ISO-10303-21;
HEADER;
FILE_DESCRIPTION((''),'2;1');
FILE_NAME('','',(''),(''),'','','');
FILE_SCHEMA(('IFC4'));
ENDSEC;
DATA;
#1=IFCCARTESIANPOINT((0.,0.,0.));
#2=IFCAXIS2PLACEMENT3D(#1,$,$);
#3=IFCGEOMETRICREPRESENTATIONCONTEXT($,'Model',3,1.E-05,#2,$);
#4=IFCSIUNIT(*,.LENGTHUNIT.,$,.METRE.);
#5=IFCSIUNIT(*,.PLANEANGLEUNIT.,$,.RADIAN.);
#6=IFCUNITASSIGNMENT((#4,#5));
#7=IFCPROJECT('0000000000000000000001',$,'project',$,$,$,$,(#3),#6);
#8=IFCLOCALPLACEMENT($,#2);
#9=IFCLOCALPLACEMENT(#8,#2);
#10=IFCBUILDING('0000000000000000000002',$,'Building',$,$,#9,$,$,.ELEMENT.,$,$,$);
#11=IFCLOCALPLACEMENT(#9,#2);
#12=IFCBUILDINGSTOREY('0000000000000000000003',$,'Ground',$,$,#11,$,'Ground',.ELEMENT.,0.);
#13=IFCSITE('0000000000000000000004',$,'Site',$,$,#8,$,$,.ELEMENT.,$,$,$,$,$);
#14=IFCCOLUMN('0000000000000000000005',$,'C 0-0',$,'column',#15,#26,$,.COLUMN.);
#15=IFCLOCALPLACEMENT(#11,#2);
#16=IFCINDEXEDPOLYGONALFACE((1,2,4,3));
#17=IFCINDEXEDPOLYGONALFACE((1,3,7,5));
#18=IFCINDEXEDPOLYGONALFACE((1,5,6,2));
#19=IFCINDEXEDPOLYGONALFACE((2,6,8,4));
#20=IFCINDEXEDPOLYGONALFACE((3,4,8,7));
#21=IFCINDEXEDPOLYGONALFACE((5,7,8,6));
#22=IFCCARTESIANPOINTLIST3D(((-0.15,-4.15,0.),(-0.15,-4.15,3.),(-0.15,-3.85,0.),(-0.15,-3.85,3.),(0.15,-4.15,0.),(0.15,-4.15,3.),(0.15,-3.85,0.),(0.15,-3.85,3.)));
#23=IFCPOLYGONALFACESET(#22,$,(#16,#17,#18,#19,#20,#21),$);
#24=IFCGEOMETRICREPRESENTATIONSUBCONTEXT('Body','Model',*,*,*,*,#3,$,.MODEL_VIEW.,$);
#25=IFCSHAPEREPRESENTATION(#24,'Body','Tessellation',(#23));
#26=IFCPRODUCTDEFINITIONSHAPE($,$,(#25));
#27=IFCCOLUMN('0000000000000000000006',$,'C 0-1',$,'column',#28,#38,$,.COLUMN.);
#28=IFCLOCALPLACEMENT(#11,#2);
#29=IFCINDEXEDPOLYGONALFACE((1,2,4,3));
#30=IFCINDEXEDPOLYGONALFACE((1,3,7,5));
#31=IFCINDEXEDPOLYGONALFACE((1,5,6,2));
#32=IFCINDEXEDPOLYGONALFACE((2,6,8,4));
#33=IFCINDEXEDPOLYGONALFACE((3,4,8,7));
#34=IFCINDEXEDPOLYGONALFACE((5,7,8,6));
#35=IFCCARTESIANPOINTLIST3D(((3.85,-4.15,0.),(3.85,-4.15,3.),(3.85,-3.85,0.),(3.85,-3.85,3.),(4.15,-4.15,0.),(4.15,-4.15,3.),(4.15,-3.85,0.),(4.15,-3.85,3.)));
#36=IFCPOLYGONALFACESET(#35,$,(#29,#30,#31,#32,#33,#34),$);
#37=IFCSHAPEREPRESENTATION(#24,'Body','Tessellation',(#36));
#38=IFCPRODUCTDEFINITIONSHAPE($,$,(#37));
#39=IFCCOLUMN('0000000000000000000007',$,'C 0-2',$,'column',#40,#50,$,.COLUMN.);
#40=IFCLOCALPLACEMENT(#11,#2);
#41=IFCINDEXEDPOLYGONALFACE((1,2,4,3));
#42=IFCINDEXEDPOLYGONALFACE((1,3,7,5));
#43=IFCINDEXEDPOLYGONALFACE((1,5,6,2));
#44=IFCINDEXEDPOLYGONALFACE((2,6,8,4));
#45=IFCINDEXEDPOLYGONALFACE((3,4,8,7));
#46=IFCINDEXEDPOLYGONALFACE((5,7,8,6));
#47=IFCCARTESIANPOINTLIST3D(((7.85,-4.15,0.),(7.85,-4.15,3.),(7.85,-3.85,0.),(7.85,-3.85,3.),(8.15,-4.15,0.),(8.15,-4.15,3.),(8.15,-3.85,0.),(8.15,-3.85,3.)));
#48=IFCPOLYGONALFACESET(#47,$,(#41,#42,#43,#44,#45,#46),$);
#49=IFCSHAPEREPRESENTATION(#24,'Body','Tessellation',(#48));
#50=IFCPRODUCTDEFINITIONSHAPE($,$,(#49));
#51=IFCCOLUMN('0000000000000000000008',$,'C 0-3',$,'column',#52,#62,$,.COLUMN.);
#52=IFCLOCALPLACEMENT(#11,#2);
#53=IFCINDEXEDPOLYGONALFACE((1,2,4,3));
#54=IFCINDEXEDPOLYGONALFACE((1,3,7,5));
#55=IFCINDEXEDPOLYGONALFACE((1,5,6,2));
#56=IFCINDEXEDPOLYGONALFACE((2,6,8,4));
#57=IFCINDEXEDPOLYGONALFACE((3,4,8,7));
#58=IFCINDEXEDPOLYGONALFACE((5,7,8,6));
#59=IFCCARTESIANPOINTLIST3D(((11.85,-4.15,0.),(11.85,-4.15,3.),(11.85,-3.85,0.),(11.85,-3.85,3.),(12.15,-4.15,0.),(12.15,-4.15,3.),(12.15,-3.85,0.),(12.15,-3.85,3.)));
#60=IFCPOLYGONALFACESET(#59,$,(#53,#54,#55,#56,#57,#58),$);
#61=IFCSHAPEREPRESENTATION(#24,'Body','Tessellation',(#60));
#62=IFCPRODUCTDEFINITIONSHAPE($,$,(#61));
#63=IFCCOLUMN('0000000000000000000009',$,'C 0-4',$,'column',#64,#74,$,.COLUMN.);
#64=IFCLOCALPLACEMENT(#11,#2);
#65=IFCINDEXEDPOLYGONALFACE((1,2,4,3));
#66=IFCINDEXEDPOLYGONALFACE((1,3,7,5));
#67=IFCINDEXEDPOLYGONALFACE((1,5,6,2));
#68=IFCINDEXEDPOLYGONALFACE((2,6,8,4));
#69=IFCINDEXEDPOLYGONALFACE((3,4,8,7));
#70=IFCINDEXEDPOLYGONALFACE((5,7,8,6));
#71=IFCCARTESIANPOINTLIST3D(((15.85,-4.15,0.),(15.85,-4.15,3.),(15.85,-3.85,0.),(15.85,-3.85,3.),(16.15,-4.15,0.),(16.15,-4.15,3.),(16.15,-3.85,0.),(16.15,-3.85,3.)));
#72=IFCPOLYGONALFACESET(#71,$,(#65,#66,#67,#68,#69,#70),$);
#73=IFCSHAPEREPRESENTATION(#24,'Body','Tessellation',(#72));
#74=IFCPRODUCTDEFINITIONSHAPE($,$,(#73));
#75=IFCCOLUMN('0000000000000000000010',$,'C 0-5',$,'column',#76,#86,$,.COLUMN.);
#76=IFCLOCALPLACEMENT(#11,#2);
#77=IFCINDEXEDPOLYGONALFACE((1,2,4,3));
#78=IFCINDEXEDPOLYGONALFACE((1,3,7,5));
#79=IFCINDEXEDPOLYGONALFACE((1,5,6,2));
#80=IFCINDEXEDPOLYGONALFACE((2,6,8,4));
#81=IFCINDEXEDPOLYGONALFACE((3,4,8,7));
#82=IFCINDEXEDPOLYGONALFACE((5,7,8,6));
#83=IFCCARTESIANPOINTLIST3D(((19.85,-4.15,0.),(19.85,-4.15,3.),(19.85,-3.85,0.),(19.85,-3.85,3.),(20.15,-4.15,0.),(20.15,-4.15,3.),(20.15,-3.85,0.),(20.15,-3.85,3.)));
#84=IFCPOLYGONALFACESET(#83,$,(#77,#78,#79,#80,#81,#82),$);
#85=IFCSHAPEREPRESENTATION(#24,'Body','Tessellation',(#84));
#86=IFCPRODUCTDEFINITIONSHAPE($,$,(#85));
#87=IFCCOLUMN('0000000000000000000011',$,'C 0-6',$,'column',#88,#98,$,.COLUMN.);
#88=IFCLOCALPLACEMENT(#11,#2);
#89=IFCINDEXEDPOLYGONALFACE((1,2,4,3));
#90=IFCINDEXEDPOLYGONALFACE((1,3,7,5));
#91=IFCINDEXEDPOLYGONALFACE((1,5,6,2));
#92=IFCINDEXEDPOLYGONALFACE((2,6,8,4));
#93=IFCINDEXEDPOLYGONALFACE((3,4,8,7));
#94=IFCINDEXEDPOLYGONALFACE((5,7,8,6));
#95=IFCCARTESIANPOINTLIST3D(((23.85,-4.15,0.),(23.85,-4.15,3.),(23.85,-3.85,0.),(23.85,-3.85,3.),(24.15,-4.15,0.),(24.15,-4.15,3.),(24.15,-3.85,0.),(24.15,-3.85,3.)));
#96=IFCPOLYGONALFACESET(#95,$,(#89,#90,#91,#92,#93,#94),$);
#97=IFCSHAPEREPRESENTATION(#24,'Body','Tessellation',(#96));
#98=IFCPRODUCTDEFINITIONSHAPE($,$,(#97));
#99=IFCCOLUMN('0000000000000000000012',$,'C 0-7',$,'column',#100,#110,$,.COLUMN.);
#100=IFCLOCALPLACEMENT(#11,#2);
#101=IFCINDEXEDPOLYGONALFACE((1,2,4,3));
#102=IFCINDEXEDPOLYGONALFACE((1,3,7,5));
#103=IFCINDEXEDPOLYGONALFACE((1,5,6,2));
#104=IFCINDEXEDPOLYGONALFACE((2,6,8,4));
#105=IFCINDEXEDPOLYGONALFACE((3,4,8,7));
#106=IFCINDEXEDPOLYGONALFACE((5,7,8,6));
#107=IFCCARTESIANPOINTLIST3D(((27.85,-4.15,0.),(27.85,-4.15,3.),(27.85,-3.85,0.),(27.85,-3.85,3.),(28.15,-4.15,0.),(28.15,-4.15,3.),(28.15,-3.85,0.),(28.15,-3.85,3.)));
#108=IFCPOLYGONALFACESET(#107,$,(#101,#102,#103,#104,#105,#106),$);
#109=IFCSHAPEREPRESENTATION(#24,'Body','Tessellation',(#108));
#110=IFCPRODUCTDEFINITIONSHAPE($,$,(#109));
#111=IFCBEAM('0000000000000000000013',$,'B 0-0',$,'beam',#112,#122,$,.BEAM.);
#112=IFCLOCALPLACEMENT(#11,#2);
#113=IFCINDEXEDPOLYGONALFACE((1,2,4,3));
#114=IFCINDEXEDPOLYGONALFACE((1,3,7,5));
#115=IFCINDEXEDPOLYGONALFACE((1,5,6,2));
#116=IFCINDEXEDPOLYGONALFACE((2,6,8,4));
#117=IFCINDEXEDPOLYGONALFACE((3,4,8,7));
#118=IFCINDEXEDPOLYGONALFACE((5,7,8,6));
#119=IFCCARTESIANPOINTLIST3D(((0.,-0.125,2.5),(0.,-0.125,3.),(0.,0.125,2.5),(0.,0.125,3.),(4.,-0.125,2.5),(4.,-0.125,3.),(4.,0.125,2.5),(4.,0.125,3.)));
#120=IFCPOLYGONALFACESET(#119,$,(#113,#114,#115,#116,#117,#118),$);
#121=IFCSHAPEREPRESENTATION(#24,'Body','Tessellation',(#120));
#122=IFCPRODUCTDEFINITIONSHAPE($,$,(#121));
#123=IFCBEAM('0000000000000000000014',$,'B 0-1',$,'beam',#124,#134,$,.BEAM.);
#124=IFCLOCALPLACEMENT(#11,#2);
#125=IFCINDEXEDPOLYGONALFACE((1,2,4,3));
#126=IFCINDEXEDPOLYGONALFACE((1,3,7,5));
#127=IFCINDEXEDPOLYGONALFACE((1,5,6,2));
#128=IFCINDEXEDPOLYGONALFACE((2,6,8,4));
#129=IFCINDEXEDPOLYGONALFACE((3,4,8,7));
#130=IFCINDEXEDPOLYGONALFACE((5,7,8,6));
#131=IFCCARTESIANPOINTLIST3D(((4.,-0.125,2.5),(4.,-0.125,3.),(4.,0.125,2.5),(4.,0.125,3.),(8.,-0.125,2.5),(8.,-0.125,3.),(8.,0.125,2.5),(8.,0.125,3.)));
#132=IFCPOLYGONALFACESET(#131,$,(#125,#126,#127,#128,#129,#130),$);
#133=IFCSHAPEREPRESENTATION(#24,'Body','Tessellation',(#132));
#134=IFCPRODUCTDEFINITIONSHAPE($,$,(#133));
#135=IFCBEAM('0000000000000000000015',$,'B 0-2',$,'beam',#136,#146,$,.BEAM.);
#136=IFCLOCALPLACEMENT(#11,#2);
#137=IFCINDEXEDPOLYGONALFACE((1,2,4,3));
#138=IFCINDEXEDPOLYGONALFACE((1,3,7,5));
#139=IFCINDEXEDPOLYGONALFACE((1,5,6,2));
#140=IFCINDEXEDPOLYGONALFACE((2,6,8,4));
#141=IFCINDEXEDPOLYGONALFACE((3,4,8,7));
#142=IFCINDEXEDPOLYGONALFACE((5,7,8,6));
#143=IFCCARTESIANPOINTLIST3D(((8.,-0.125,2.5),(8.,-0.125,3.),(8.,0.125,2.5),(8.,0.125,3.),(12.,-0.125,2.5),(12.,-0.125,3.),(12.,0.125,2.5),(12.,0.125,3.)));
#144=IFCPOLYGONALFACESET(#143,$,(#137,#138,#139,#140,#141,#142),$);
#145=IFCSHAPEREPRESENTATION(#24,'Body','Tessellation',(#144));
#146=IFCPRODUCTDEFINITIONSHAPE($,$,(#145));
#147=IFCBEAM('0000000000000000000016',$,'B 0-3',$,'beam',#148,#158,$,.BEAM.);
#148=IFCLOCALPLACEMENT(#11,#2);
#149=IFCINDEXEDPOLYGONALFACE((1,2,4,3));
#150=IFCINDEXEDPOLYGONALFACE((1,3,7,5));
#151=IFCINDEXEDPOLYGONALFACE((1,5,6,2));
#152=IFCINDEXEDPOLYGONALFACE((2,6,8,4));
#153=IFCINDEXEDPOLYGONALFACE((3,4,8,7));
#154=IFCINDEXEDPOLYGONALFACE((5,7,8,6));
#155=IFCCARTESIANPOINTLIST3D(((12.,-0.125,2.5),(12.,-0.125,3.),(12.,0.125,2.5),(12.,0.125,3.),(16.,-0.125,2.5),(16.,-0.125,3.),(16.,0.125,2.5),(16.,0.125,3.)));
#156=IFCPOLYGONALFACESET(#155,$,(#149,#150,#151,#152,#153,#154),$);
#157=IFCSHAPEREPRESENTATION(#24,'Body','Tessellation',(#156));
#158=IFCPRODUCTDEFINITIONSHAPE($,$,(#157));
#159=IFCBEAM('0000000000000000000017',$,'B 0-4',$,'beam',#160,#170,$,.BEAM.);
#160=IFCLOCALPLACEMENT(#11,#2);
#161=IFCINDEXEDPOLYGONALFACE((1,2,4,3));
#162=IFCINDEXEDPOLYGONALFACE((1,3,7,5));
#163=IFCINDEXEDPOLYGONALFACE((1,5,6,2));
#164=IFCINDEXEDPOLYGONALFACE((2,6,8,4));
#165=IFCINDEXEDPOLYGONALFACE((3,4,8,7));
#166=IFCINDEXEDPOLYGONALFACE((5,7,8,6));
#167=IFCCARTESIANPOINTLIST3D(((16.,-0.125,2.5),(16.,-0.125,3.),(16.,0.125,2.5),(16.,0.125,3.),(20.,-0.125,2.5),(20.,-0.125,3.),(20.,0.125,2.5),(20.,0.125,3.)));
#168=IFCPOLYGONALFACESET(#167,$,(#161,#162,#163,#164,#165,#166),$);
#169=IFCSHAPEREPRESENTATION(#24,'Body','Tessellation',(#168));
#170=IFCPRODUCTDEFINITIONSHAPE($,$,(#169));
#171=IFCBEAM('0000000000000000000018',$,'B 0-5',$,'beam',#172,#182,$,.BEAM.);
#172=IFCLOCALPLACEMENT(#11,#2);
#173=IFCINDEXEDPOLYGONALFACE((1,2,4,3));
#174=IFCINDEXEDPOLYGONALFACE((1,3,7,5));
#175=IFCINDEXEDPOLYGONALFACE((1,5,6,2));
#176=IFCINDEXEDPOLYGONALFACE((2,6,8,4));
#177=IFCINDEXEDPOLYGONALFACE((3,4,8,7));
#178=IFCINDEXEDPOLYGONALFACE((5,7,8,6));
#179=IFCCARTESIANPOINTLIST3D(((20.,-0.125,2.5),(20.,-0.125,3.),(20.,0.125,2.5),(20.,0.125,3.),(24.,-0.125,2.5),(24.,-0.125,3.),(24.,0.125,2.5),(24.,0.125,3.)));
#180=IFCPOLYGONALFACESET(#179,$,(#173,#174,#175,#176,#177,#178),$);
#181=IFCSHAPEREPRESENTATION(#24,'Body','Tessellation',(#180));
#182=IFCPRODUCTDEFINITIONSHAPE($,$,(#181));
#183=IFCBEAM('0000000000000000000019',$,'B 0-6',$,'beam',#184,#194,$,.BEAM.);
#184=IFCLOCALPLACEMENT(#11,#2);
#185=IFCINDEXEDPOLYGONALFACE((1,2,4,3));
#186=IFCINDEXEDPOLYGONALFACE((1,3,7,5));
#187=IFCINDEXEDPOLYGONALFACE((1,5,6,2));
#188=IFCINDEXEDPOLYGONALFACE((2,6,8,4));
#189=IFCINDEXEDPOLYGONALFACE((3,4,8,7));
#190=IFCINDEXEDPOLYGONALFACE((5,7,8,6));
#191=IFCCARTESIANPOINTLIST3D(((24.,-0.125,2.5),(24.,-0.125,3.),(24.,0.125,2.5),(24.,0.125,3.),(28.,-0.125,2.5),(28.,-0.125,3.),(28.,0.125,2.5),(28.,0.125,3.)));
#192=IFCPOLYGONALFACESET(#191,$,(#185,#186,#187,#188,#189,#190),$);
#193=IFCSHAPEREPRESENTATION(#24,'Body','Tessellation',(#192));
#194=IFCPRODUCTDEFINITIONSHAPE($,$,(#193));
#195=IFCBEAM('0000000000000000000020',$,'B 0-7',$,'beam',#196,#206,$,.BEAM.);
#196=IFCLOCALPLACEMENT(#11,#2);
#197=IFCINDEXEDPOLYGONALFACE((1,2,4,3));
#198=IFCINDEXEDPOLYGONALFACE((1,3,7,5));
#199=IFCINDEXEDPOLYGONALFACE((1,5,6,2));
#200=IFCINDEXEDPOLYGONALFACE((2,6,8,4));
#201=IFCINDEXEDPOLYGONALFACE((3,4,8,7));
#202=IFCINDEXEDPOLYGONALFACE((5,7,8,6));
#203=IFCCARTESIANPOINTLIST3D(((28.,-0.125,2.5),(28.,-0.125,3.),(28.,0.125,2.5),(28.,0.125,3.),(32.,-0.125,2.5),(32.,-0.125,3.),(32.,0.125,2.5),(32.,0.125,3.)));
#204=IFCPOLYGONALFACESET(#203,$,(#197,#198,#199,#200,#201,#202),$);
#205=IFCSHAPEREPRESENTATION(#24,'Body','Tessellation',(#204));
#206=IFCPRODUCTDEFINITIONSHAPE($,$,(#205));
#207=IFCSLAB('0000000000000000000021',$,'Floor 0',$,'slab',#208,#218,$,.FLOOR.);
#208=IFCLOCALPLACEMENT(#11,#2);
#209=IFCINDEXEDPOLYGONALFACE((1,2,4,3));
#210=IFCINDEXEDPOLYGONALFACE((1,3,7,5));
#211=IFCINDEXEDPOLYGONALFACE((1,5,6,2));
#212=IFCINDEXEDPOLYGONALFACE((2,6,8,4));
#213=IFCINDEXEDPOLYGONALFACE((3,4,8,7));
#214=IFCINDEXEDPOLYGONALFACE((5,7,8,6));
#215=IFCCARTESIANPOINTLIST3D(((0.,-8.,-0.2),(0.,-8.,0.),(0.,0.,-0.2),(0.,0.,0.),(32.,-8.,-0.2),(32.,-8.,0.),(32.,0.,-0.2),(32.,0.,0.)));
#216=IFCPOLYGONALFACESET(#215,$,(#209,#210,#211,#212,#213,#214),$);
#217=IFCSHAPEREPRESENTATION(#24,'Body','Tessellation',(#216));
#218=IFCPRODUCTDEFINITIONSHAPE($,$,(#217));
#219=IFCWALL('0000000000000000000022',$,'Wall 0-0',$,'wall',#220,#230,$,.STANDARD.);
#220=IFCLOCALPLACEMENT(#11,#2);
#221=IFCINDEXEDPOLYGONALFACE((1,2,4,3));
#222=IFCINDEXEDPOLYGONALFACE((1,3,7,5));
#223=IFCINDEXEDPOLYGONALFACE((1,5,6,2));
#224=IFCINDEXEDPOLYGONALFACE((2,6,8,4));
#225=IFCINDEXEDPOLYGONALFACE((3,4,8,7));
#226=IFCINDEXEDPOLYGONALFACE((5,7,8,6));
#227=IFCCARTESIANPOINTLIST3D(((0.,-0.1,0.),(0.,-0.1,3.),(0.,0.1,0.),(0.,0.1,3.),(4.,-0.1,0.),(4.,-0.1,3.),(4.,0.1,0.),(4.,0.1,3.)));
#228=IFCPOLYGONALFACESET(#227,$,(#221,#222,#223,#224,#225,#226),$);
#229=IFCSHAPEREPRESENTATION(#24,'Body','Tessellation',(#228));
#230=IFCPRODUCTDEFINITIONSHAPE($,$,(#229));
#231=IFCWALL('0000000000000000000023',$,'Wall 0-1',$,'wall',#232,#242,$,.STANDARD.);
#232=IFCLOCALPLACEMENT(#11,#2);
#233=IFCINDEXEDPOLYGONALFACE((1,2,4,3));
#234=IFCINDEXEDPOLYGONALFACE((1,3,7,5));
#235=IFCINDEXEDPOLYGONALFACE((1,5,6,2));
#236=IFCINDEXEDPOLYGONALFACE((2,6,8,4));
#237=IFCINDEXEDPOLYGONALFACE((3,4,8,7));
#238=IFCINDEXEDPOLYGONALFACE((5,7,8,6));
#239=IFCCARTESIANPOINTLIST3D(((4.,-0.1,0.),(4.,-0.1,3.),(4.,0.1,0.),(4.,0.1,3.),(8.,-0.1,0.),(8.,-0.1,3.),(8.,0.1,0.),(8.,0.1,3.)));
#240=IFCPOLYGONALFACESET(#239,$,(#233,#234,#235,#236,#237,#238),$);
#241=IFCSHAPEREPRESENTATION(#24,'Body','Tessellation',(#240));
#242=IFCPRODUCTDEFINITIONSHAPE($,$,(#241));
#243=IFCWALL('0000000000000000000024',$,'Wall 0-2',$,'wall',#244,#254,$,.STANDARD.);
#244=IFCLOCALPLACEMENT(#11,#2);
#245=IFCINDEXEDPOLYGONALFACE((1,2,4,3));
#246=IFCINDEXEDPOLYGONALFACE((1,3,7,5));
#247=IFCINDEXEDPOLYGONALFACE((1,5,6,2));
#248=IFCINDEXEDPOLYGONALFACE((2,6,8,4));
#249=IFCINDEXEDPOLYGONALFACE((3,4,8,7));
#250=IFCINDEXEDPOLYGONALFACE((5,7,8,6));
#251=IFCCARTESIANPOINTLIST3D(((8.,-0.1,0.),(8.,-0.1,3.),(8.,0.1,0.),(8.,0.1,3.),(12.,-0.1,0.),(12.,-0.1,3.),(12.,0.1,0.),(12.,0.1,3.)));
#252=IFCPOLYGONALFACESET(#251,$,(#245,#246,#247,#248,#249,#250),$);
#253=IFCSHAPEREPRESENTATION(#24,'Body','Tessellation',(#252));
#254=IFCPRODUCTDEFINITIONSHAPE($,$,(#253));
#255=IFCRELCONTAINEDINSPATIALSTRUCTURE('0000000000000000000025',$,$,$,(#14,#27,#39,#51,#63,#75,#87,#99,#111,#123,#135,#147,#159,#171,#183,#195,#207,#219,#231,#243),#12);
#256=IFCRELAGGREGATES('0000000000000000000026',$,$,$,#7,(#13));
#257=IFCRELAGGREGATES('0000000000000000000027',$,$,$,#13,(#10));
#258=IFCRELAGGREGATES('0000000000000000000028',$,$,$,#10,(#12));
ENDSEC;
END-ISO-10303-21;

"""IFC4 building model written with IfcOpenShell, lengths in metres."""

from ifc_helpers import new_model, si_unit, frame, frame_2d, origin, origin_2d, place, context, subcontext, project, spatial, polyline, rectangle, outline, extrude, element, save


model = new_model("IFC4")

# Units and contexts
model_context = context("Model", 3, precision=1e-05, world=origin())
body_context = subcontext(model_context, "Body", "Model", "MODEL_VIEW")
ifc_project = project(units=[si_unit("LENGTHUNIT", "METRE"), si_unit("PLANEANGLEUNIT", "RADIAN")], contexts=[model_context])

# Site, building, storey
site_placement = place(None, origin())
site = spatial("IfcSite", under=ifc_project, at=site_placement, Name="Site", CompositionType="ELEMENT")
building_placement = place(site_placement, origin())
building = spatial("IfcBuilding", under=site, at=building_placement, Name="Building", CompositionType="ELEMENT")
storey_placement = place(building_placement, origin())
storey = spatial("IfcBuildingStorey", under=building, at=storey_placement, Name="Ground", LongName="Ground", CompositionType="ELEMENT", Elevation=0.0)

# Columns
for number, where, name in (
    (1, (0.0, -4.0, 0.0), "C 0-0"),
    (2, (4.0, -4.0, 0.0), "C 0-1"),
    (3, (8.0, -4.0, 0.0), "C 0-2"),
    (4, (12.0, -4.0, 0.0), "C 0-3"),
    (5, (16.0, -4.0, 0.0), "C 0-4"),
    (6, (20.0, -4.0, 0.0), "C 0-5"),
    (7, (24.0, -4.0, 0.0), "C 0-6"),
    (8, (28.0, -4.0, 0.0), "C 0-7"),
):
    element("IfcColumn", number, at=place(storey_placement, frame(where)), inside=storey, Name=name, ObjectType="column", PredefinedType="COLUMN", context=body_context, shape_type="SweptSolid", body=[
        extrude(rectangle(XDim=0.3, YDim=0.3, at=origin_2d()), origin(), (0.0, 0.0, 1.0), 3.0),
    ])

# Beams
for number, where, z_axis, x_axis, name in (
    (9, (0.0, 0.0, 2.75), (1.0, 0.0, 0.0), (0.0, 0.0, 1.0), "B 0-0"),
    (10, (4.0, 0.0, 2.75), (1.0, 0.0, 0.0), (0.0, 0.0, 1.0), "B 0-1"),
    (11, (8.0, 0.0, 2.75), (1.0, 0.0, 0.0), (0.0, 0.0, 1.0), "B 0-2"),
    (12, (12.0, 0.0, 2.75), (1.0, 0.0, 0.0), (0.0, 0.0, 1.0), "B 0-3"),
    (13, (16.0, 0.0, 2.75), (1.0, 0.0, 0.0), (0.0, 0.0, 1.0), "B 0-4"),
    (14, (20.0, 0.0, 2.75), (1.0, 0.0, 0.0), (0.0, 0.0, 1.0), "B 0-5"),
    (15, (24.0, 0.0, 2.75), (1.0, 0.0, 0.0), (0.0, 0.0, 1.0), "B 0-6"),
    (16, (28.0, 0.0, 2.75), (1.0, 0.0, 0.0), (0.0, 0.0, 1.0), "B 0-7"),
):
    element("IfcBeam", number, at=place(storey_placement, frame(where, z_axis=z_axis, x_axis=x_axis)), inside=storey, Name=name, ObjectType="beam", PredefinedType="BEAM", context=body_context, shape_type="SweptSolid", body=[
        extrude(rectangle(XDim=0.5, YDim=0.25, at=origin_2d()), origin(), (0.0, 0.0, 1.0), 4.0),
    ])

# Slab
slab_placement = place(storey_placement, frame((0.0, 0.0, -0.2)))
element("IfcSlab", 17, at=slab_placement, inside=storey, Name="Floor 0", ObjectType="slab", PredefinedType="FLOOR", context=body_context, shape_type="SweptSolid", body=[
    extrude(outline(polyline([(0.0, -8.0), (32.0, -8.0), (32.0, 0.0), (0.0, 0.0), (0.0, -8.0)])), origin(), (0.0, 0.0, 1.0), 0.2),
])

# Walls
for number, where, z_axis, x_axis, name in (
    (18, (0.0, 0.0, 0.0), (0.0, 0.0, 1.0), (1.0, 0.0, 0.0), "Wall 0-0"),
    (19, (4.0, 0.0, 0.0), (0.0, 0.0, 1.0), (1.0, 0.0, 0.0), "Wall 0-1"),
    (20, (8.0, 0.0, 0.0), (0.0, 0.0, 1.0), (1.0, 0.0, 0.0), "Wall 0-2"),
):
    element("IfcWall", number, at=place(storey_placement, frame(where, z_axis=z_axis, x_axis=x_axis)), inside=storey, Name=name, ObjectType="wall", PredefinedType="STANDARD", context=body_context, shape_type="SweptSolid", body=[
        extrude(rectangle(XDim=4.0, YDim=0.2, at=frame_2d((2.0, 0.0))), origin(), (0.0, 0.0, 1.0), 3.0),
    ])

save(model, "model.ifc")
